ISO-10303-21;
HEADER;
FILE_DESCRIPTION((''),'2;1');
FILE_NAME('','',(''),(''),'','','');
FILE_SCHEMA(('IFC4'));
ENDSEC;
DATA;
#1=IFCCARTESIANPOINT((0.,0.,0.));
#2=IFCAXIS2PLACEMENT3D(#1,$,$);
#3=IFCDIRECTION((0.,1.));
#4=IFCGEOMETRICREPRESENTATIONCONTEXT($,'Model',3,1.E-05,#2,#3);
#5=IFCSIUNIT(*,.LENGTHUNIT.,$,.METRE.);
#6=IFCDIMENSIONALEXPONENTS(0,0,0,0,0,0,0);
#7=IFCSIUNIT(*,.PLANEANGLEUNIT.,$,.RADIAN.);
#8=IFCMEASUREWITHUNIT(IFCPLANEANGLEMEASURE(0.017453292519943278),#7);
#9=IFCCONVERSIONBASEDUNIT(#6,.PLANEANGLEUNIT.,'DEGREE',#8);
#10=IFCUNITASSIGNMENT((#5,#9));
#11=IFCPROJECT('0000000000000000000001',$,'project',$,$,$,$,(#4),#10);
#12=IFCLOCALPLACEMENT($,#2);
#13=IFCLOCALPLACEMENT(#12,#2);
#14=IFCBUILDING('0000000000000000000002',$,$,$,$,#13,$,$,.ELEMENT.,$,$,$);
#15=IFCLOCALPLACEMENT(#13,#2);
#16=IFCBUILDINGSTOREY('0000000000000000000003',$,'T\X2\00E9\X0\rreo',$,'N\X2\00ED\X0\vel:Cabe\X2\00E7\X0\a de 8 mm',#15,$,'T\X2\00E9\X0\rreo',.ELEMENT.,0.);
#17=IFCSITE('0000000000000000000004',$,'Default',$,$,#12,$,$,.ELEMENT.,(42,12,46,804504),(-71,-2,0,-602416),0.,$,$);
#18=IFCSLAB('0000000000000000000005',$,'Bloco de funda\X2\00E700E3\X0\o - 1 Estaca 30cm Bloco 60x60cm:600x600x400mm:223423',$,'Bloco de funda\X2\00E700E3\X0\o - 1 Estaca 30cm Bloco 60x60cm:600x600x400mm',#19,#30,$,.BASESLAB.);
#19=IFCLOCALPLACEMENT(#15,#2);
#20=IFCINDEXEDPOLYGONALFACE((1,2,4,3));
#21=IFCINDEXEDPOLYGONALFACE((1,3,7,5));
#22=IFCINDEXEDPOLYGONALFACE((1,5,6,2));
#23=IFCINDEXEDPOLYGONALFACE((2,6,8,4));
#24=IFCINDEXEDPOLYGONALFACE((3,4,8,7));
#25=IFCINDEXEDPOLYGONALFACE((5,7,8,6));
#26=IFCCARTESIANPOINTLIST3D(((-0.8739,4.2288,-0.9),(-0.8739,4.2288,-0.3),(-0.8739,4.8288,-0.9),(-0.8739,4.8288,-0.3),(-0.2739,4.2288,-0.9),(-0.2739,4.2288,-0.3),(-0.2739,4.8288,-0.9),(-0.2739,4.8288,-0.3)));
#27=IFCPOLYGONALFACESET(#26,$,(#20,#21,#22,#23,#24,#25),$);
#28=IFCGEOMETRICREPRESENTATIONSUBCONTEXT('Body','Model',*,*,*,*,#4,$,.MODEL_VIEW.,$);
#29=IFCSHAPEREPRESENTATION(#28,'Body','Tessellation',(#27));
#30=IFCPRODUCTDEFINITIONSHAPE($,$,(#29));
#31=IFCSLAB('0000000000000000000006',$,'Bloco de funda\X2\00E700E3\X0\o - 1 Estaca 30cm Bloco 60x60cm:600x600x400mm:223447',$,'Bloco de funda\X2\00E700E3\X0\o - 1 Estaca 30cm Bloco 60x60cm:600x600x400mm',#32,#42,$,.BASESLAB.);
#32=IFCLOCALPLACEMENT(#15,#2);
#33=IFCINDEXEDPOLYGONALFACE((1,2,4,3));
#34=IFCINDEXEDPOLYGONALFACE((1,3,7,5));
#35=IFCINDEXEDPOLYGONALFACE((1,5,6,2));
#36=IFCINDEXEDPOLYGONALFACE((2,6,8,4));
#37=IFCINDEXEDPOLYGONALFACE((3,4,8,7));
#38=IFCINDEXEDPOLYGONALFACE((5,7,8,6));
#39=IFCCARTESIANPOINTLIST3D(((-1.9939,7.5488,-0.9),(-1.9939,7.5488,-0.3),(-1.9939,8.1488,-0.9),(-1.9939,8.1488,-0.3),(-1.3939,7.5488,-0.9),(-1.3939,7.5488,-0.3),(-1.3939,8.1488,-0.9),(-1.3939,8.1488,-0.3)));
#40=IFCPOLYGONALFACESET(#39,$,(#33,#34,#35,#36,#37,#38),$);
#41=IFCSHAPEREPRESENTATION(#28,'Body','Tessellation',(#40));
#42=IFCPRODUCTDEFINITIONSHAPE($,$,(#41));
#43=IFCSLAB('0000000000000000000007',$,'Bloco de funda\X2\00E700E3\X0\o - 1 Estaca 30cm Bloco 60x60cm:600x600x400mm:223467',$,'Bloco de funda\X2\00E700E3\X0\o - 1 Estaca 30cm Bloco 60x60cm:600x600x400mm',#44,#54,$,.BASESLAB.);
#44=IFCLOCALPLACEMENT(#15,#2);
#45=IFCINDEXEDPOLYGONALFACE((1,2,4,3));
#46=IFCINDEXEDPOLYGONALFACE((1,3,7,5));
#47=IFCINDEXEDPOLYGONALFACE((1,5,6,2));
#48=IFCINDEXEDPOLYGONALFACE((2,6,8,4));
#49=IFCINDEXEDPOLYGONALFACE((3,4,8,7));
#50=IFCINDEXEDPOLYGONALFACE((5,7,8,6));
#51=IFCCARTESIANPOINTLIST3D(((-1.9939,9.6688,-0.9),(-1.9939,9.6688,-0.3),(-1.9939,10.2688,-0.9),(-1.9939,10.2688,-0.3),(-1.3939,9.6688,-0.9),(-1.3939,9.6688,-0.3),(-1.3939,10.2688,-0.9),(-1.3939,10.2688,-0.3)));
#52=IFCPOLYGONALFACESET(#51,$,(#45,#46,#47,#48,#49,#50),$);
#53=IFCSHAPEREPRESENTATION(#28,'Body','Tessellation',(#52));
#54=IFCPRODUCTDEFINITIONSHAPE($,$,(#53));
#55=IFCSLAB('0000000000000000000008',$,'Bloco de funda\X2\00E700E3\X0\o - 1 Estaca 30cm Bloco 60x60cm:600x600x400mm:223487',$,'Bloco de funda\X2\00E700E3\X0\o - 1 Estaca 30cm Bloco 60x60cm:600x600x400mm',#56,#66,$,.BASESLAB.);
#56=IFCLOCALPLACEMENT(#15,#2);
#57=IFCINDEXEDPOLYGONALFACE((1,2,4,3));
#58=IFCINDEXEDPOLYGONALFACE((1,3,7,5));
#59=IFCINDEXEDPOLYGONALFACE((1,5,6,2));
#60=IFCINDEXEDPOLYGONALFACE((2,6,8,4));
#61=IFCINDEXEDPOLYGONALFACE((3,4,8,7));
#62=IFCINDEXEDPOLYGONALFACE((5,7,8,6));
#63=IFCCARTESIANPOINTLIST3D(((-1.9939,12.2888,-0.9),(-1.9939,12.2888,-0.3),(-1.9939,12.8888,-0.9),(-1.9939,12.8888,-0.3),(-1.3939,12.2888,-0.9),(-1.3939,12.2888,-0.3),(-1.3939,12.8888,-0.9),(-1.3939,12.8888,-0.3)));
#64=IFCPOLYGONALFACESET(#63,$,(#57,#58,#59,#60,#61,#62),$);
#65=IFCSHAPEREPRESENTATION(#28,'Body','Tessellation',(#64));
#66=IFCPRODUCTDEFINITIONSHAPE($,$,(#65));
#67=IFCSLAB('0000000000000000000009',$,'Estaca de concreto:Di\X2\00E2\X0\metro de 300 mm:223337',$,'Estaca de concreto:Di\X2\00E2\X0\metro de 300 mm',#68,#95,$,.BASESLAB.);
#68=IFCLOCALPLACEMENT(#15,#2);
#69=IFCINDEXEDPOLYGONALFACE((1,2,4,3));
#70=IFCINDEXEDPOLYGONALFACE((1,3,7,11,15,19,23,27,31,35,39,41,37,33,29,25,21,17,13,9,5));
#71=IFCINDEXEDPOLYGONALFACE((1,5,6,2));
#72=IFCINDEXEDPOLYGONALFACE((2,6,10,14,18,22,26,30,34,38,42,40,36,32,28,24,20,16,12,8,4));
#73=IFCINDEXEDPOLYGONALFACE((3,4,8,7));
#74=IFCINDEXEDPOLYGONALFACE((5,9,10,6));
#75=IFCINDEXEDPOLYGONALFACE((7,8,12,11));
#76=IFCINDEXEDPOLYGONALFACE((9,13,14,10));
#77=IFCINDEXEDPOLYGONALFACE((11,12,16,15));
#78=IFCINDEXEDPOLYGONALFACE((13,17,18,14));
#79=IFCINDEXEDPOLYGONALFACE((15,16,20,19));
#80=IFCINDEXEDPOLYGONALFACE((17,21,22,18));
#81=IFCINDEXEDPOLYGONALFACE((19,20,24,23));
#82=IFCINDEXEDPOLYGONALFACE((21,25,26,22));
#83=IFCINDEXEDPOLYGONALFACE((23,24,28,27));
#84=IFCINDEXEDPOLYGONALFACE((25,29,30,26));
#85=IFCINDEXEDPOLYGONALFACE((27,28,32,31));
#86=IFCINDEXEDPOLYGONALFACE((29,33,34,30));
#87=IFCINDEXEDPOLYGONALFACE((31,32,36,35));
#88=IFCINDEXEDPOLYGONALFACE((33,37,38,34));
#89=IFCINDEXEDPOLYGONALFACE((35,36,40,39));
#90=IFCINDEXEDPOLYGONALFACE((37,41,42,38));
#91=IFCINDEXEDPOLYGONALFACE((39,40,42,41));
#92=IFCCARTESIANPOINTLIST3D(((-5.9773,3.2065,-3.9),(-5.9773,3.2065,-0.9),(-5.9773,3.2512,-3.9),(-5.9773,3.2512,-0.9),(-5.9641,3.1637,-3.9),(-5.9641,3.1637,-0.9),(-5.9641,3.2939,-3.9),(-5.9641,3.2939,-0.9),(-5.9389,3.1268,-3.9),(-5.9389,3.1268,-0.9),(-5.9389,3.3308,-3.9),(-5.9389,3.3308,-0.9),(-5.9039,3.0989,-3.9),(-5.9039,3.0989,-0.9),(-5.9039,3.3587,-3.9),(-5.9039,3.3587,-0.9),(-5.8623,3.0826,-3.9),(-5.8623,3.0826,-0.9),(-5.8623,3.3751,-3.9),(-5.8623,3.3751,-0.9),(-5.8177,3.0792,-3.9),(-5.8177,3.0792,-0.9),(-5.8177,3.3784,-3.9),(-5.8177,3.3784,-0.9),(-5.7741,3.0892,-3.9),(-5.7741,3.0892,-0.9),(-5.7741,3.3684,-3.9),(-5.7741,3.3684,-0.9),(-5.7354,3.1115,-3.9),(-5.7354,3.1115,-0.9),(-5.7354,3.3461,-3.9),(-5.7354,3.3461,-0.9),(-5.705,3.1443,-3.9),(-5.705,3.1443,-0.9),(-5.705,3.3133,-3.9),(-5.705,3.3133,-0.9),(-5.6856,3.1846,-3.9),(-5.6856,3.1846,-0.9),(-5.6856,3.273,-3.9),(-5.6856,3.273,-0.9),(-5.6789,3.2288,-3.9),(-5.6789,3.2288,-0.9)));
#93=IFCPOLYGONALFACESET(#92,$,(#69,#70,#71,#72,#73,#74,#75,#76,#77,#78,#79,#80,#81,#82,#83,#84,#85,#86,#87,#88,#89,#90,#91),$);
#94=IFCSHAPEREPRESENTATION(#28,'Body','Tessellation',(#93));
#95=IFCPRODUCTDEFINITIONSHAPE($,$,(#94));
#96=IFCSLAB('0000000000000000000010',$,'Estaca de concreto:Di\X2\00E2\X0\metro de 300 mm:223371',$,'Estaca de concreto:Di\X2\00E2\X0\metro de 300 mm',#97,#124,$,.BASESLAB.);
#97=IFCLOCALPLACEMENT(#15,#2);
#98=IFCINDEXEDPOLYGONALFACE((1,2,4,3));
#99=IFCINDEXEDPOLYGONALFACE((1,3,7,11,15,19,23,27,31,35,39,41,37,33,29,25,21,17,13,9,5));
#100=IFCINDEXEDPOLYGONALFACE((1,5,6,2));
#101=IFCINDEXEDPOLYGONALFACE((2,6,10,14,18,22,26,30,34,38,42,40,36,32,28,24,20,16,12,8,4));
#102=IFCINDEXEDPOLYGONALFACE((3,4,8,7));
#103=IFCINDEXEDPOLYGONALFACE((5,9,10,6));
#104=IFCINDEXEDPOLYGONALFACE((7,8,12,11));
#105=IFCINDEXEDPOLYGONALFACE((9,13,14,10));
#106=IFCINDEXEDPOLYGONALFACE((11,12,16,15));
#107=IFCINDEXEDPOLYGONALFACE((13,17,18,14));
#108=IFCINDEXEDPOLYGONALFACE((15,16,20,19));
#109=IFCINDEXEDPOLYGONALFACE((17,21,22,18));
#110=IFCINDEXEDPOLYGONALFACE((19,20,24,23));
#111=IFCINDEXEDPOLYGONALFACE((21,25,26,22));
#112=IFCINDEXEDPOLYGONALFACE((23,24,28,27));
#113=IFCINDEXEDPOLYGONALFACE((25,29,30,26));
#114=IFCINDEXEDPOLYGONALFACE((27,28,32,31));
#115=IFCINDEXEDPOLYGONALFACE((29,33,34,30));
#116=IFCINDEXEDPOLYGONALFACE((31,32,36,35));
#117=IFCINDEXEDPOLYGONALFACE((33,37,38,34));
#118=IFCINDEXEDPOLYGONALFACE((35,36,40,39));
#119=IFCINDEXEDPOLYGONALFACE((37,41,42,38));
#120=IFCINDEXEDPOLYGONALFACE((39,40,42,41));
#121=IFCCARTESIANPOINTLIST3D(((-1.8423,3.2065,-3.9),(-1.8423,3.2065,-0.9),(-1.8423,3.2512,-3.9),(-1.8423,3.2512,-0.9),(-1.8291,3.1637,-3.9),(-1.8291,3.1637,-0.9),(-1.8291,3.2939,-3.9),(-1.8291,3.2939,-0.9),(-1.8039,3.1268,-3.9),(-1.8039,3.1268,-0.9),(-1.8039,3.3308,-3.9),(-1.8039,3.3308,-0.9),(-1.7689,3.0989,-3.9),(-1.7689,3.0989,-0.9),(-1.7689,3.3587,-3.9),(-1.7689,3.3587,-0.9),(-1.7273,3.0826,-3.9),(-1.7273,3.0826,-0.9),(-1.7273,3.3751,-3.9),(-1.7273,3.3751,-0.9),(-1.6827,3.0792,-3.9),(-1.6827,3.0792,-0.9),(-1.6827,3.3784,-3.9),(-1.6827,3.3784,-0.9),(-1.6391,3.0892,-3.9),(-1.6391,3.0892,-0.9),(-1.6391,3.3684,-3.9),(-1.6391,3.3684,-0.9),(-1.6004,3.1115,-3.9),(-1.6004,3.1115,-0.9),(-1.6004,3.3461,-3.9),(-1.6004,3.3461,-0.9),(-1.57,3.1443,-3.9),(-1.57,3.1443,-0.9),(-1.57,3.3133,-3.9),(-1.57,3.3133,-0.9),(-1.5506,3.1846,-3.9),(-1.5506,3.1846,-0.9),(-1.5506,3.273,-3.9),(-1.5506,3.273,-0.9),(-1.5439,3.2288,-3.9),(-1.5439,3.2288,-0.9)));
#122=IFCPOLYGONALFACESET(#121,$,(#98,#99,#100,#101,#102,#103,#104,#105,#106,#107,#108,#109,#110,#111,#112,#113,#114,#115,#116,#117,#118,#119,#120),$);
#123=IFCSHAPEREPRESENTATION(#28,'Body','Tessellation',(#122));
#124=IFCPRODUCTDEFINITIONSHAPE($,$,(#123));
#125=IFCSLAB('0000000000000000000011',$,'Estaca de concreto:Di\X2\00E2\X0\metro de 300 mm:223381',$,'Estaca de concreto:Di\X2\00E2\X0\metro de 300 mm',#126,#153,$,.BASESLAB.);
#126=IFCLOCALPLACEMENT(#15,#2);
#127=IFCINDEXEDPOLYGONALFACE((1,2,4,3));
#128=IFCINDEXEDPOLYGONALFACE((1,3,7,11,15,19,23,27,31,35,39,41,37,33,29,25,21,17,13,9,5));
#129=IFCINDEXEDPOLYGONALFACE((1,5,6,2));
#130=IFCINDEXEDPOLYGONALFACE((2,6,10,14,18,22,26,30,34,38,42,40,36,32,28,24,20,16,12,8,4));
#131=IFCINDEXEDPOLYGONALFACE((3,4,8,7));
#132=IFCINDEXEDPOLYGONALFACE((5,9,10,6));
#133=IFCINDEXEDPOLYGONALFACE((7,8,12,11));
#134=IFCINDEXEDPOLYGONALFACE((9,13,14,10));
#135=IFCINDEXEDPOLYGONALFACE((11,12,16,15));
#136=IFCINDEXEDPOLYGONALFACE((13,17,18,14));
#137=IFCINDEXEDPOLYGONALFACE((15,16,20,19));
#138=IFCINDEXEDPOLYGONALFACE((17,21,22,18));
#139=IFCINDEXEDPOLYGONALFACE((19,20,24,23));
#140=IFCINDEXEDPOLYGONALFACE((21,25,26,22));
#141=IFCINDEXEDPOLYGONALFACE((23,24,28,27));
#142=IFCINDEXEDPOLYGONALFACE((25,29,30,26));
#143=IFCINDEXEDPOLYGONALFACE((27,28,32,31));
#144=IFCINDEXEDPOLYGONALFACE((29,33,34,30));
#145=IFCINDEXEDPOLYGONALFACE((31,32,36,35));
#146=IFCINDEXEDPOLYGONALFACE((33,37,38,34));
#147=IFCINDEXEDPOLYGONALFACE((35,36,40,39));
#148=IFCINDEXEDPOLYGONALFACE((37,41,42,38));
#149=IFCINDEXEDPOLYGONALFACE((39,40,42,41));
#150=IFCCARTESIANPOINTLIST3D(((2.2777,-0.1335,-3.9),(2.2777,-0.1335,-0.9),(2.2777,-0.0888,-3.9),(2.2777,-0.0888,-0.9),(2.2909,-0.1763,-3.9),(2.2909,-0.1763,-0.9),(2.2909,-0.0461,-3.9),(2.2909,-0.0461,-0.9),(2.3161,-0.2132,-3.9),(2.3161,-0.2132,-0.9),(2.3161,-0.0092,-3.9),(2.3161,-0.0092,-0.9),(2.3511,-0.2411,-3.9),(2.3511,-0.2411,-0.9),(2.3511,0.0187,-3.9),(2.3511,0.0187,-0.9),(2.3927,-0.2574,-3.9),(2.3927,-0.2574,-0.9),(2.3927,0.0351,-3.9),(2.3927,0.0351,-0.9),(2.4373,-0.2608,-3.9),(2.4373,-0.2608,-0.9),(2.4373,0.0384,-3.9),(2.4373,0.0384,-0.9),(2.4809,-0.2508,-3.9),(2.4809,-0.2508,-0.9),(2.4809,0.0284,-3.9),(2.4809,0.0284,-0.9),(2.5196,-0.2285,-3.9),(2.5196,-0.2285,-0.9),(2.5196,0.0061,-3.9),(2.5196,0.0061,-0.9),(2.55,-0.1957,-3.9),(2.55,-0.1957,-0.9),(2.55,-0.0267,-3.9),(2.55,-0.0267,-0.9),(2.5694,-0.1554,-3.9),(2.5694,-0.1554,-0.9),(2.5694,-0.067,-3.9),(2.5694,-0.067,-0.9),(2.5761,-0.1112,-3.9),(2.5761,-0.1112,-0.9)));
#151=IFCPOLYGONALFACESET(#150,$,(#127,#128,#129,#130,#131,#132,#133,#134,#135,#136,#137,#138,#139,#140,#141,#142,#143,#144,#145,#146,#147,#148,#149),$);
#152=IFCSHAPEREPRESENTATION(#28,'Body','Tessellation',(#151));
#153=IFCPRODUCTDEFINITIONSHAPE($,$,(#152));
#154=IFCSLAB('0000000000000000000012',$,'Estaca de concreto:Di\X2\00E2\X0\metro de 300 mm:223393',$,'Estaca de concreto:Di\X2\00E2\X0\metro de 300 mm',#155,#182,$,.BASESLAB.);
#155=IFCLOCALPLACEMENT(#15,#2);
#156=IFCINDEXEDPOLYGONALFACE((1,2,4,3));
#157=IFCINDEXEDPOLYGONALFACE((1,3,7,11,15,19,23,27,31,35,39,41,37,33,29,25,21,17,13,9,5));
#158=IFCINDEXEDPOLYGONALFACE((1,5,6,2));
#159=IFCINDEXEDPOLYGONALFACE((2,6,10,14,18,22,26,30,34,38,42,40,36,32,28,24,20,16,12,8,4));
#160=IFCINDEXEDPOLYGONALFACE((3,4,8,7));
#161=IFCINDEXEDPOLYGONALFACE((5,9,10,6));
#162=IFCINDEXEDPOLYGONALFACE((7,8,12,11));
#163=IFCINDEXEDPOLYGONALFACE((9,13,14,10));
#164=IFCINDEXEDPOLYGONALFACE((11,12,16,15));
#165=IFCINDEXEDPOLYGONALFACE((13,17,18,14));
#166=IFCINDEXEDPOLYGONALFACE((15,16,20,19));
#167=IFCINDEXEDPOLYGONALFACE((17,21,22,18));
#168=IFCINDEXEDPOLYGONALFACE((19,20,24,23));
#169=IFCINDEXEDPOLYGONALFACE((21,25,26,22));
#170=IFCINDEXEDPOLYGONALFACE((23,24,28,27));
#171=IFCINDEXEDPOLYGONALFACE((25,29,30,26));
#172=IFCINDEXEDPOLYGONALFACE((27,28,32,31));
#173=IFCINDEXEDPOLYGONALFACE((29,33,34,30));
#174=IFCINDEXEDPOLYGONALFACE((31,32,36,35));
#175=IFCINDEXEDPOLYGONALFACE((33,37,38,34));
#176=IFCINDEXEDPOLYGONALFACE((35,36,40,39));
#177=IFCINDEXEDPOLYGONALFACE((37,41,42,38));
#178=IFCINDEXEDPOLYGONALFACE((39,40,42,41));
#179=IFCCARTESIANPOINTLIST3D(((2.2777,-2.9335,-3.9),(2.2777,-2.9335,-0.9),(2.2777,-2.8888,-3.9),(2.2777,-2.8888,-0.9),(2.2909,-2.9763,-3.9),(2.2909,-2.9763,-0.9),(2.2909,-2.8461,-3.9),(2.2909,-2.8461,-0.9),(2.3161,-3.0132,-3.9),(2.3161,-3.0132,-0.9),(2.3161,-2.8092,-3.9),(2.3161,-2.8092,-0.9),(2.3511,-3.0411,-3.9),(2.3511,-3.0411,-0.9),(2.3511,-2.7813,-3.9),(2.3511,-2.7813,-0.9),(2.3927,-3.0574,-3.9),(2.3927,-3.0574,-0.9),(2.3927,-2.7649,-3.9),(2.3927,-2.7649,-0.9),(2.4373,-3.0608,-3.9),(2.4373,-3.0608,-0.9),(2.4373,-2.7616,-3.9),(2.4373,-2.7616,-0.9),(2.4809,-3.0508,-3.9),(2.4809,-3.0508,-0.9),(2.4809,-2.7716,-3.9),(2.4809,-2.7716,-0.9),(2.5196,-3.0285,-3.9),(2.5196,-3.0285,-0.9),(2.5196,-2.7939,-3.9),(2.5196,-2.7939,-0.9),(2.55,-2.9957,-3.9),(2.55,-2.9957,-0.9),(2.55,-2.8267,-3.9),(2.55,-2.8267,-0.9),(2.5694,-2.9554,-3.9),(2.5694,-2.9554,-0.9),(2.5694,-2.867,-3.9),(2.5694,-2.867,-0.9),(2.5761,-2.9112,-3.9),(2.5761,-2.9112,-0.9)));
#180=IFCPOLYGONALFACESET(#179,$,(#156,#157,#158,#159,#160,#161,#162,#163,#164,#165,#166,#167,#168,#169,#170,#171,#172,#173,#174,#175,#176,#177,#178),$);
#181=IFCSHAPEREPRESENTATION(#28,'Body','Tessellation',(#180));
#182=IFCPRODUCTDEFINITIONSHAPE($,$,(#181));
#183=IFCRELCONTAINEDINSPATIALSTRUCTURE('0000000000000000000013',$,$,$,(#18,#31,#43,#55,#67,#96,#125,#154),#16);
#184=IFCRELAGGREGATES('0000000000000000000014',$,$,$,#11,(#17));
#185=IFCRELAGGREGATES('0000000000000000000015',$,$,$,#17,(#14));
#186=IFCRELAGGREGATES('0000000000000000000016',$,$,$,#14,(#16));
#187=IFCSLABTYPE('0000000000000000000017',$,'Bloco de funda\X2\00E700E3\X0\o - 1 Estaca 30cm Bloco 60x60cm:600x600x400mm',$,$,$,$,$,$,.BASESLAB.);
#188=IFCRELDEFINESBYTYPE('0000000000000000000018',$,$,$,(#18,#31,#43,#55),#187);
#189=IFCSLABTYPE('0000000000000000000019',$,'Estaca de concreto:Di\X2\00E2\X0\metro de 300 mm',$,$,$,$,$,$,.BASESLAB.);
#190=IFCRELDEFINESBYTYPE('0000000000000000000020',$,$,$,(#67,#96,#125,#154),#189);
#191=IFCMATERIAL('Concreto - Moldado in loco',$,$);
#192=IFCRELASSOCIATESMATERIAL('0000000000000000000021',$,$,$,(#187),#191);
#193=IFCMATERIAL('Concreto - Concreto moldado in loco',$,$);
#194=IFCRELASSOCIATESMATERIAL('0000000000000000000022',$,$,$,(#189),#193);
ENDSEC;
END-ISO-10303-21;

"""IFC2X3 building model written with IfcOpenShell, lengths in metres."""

from ifc_helpers import new_model, entity, si_unit, converted_unit, direction, frame, frame_2d, origin, origin_2d_with_axis, place, context, subcontext, project, spatial, rectangle, circle, extrude, material, type_object, element, save


model = new_model("IFC2X3")

# Units and contexts
model_context = context("Model", 3, precision=1e-05, world=origin(), true_north=direction((0.0, 1.0)))
body_context = subcontext(model_context, "Body", "Model", "MODEL_VIEW")
ifc_project = project(units=[si_unit("LENGTHUNIT", "METRE"), converted_unit("PLANEANGLEUNIT", "DEGREE", entity("IfcPlaneAngleMeasure", 0.017453292519943278), si_unit("PLANEANGLEUNIT", "RADIAN"), dimensions=[0, 0, 0, 0, 0, 0, 0])], contexts=[model_context])

# Site, building, storey
site_placement = place(None, origin())
site = spatial("IfcSite", under=ifc_project, at=site_placement, Name="Default", CompositionType="ELEMENT", RefLatitude=(42, 12, 46, 804504), RefLongitude=(-71, -2, 0, -602416), RefElevation=0.0)
building_placement = place(site_placement, origin())
building = spatial("IfcBuilding", under=site, at=building_placement, CompositionType="ELEMENT")
storey_placement = place(building_placement, origin())
storey = spatial("IfcBuildingStorey", under=building, at=storey_placement, Name="Térreo", ObjectType="Nível:Cabeça de 8 mm", LongName="Térreo", CompositionType="ELEMENT", Elevation=0.0)

# Slabs
ifc_material_1 = material(Name="Concreto - Moldado in loco")
slab_type_1 = type_object("IfcSlabType", Name="Bloco de fundação - 1 Estaca 30cm Bloco 60x60cm:600x600x400mm", PredefinedType="BASESLAB", material=ifc_material_1)
slab_1_placement = place(storey_placement, origin())
element("IfcSlab", 1, at=slab_1_placement, inside=storey, type_object=slab_type_1, Name="Bloco de fundação - 1 Estaca 30cm Bloco 60x60cm:600x600x400mm:223423", ObjectType="Bloco de fundação - 1 Estaca 30cm Bloco 60x60cm:600x600x400mm", PredefinedType="BASESLAB", context=body_context, shape_type="SweptSolid", body=[
    extrude(rectangle(XDim=0.6, YDim=0.6, at=origin_2d_with_axis()), frame((-0.5739, 4.5288, -0.9), z_axis=(0.0, 0.0, 1.0), x_axis=(-1.0, 0.0, 0.0)), (0.0, 0.0, 1.0), 0.6),
])
slab_2_placement = place(storey_placement, origin())
element("IfcSlab", 2, at=slab_2_placement, inside=storey, type_object=slab_type_1, Name="Bloco de fundação - 1 Estaca 30cm Bloco 60x60cm:600x600x400mm:223447", ObjectType="Bloco de fundação - 1 Estaca 30cm Bloco 60x60cm:600x600x400mm", PredefinedType="BASESLAB", context=body_context, shape_type="SweptSolid", body=[
    extrude(rectangle(XDim=0.6, YDim=0.6, at=frame_2d((0.0, 0.0), x_axis=(1.0, 0.0))), frame((-1.6939, 7.8488, -0.9), z_axis=(0.0, 0.0, 1.0), x_axis=(-1.0, 0.0, 0.0)), (0.0, 0.0, 1.0), 0.6),
])
slab_3_placement = place(storey_placement, origin())
element("IfcSlab", 3, at=slab_3_placement, inside=storey, type_object=slab_type_1, Name="Bloco de fundação - 1 Estaca 30cm Bloco 60x60cm:600x600x400mm:223467", ObjectType="Bloco de fundação - 1 Estaca 30cm Bloco 60x60cm:600x600x400mm", PredefinedType="BASESLAB", context=body_context, shape_type="SweptSolid", body=[
    extrude(rectangle(XDim=0.6, YDim=0.6, at=frame_2d((0.0, 0.0), x_axis=(1.0, 0.0))), frame((-1.6939, 9.9688, -0.9), z_axis=(0.0, 0.0, 1.0), x_axis=(-1.0, 0.0, 0.0)), (0.0, 0.0, 1.0), 0.6),
])
slab_4_placement = place(storey_placement, origin())
element("IfcSlab", 4, at=slab_4_placement, inside=storey, type_object=slab_type_1, Name="Bloco de fundação - 1 Estaca 30cm Bloco 60x60cm:600x600x400mm:223487", ObjectType="Bloco de fundação - 1 Estaca 30cm Bloco 60x60cm:600x600x400mm", PredefinedType="BASESLAB", context=body_context, shape_type="SweptSolid", body=[
    extrude(rectangle(XDim=0.6, YDim=0.6, at=frame_2d((0.0, 0.0), x_axis=(1.0, 0.0))), frame((-1.6939, 12.5888, -0.9), z_axis=(0.0, 0.0, 1.0), x_axis=(-1.0, 0.0, 0.0)), (0.0, 0.0, 1.0), 0.6),
])
ifc_material_2 = material(Name="Concreto - Concreto moldado in loco")
slab_type_2 = type_object("IfcSlabType", Name="Estaca de concreto:Diâmetro de 300 mm", PredefinedType="BASESLAB", material=ifc_material_2)
slab_5_placement = place(storey_placement, origin())
element("IfcSlab", 5, at=slab_5_placement, inside=storey, type_object=slab_type_2, Name="Estaca de concreto:Diâmetro de 300 mm:223337", ObjectType="Estaca de concreto:Diâmetro de 300 mm", PredefinedType="BASESLAB", context=body_context, shape_type="SweptSolid", body=[
    extrude(circle(Radius=0.15, at=frame_2d((0.0, 0.0), x_axis=(1.0, 0.0))), frame((-5.8289, 3.2288, -3.9)), (0.0, 0.0, 1.0), 3.0),
])
slab_6_placement = place(storey_placement, origin())
element("IfcSlab", 6, at=slab_6_placement, inside=storey, type_object=slab_type_2, Name="Estaca de concreto:Diâmetro de 300 mm:223371", ObjectType="Estaca de concreto:Diâmetro de 300 mm", PredefinedType="BASESLAB", context=body_context, shape_type="SweptSolid", body=[
    extrude(circle(Radius=0.15, at=frame_2d((0.0, 0.0), x_axis=(1.0, 0.0))), frame((-1.6939, 3.2288, -3.9)), (0.0, 0.0, 1.0), 3.0),
])
slab_7_placement = place(storey_placement, origin())
element("IfcSlab", 7, at=slab_7_placement, inside=storey, type_object=slab_type_2, Name="Estaca de concreto:Diâmetro de 300 mm:223381", ObjectType="Estaca de concreto:Diâmetro de 300 mm", PredefinedType="BASESLAB", context=body_context, shape_type="SweptSolid", body=[
    extrude(circle(Radius=0.15, at=frame_2d((0.0, 0.0), x_axis=(1.0, 0.0))), frame((2.4261, -0.1112, -3.9)), (0.0, 0.0, 1.0), 3.0),
])
slab_8_placement = place(storey_placement, origin())
element("IfcSlab", 8, at=slab_8_placement, inside=storey, type_object=slab_type_2, Name="Estaca de concreto:Diâmetro de 300 mm:223393", ObjectType="Estaca de concreto:Diâmetro de 300 mm", PredefinedType="BASESLAB", context=body_context, shape_type="SweptSolid", body=[
    extrude(circle(Radius=0.15, at=frame_2d((0.0, 0.0), x_axis=(1.0, 0.0))), frame((2.4261, -2.9112, -3.9)), (0.0, 0.0, 1.0), 3.0),
])

save(model, "model.ifc")
